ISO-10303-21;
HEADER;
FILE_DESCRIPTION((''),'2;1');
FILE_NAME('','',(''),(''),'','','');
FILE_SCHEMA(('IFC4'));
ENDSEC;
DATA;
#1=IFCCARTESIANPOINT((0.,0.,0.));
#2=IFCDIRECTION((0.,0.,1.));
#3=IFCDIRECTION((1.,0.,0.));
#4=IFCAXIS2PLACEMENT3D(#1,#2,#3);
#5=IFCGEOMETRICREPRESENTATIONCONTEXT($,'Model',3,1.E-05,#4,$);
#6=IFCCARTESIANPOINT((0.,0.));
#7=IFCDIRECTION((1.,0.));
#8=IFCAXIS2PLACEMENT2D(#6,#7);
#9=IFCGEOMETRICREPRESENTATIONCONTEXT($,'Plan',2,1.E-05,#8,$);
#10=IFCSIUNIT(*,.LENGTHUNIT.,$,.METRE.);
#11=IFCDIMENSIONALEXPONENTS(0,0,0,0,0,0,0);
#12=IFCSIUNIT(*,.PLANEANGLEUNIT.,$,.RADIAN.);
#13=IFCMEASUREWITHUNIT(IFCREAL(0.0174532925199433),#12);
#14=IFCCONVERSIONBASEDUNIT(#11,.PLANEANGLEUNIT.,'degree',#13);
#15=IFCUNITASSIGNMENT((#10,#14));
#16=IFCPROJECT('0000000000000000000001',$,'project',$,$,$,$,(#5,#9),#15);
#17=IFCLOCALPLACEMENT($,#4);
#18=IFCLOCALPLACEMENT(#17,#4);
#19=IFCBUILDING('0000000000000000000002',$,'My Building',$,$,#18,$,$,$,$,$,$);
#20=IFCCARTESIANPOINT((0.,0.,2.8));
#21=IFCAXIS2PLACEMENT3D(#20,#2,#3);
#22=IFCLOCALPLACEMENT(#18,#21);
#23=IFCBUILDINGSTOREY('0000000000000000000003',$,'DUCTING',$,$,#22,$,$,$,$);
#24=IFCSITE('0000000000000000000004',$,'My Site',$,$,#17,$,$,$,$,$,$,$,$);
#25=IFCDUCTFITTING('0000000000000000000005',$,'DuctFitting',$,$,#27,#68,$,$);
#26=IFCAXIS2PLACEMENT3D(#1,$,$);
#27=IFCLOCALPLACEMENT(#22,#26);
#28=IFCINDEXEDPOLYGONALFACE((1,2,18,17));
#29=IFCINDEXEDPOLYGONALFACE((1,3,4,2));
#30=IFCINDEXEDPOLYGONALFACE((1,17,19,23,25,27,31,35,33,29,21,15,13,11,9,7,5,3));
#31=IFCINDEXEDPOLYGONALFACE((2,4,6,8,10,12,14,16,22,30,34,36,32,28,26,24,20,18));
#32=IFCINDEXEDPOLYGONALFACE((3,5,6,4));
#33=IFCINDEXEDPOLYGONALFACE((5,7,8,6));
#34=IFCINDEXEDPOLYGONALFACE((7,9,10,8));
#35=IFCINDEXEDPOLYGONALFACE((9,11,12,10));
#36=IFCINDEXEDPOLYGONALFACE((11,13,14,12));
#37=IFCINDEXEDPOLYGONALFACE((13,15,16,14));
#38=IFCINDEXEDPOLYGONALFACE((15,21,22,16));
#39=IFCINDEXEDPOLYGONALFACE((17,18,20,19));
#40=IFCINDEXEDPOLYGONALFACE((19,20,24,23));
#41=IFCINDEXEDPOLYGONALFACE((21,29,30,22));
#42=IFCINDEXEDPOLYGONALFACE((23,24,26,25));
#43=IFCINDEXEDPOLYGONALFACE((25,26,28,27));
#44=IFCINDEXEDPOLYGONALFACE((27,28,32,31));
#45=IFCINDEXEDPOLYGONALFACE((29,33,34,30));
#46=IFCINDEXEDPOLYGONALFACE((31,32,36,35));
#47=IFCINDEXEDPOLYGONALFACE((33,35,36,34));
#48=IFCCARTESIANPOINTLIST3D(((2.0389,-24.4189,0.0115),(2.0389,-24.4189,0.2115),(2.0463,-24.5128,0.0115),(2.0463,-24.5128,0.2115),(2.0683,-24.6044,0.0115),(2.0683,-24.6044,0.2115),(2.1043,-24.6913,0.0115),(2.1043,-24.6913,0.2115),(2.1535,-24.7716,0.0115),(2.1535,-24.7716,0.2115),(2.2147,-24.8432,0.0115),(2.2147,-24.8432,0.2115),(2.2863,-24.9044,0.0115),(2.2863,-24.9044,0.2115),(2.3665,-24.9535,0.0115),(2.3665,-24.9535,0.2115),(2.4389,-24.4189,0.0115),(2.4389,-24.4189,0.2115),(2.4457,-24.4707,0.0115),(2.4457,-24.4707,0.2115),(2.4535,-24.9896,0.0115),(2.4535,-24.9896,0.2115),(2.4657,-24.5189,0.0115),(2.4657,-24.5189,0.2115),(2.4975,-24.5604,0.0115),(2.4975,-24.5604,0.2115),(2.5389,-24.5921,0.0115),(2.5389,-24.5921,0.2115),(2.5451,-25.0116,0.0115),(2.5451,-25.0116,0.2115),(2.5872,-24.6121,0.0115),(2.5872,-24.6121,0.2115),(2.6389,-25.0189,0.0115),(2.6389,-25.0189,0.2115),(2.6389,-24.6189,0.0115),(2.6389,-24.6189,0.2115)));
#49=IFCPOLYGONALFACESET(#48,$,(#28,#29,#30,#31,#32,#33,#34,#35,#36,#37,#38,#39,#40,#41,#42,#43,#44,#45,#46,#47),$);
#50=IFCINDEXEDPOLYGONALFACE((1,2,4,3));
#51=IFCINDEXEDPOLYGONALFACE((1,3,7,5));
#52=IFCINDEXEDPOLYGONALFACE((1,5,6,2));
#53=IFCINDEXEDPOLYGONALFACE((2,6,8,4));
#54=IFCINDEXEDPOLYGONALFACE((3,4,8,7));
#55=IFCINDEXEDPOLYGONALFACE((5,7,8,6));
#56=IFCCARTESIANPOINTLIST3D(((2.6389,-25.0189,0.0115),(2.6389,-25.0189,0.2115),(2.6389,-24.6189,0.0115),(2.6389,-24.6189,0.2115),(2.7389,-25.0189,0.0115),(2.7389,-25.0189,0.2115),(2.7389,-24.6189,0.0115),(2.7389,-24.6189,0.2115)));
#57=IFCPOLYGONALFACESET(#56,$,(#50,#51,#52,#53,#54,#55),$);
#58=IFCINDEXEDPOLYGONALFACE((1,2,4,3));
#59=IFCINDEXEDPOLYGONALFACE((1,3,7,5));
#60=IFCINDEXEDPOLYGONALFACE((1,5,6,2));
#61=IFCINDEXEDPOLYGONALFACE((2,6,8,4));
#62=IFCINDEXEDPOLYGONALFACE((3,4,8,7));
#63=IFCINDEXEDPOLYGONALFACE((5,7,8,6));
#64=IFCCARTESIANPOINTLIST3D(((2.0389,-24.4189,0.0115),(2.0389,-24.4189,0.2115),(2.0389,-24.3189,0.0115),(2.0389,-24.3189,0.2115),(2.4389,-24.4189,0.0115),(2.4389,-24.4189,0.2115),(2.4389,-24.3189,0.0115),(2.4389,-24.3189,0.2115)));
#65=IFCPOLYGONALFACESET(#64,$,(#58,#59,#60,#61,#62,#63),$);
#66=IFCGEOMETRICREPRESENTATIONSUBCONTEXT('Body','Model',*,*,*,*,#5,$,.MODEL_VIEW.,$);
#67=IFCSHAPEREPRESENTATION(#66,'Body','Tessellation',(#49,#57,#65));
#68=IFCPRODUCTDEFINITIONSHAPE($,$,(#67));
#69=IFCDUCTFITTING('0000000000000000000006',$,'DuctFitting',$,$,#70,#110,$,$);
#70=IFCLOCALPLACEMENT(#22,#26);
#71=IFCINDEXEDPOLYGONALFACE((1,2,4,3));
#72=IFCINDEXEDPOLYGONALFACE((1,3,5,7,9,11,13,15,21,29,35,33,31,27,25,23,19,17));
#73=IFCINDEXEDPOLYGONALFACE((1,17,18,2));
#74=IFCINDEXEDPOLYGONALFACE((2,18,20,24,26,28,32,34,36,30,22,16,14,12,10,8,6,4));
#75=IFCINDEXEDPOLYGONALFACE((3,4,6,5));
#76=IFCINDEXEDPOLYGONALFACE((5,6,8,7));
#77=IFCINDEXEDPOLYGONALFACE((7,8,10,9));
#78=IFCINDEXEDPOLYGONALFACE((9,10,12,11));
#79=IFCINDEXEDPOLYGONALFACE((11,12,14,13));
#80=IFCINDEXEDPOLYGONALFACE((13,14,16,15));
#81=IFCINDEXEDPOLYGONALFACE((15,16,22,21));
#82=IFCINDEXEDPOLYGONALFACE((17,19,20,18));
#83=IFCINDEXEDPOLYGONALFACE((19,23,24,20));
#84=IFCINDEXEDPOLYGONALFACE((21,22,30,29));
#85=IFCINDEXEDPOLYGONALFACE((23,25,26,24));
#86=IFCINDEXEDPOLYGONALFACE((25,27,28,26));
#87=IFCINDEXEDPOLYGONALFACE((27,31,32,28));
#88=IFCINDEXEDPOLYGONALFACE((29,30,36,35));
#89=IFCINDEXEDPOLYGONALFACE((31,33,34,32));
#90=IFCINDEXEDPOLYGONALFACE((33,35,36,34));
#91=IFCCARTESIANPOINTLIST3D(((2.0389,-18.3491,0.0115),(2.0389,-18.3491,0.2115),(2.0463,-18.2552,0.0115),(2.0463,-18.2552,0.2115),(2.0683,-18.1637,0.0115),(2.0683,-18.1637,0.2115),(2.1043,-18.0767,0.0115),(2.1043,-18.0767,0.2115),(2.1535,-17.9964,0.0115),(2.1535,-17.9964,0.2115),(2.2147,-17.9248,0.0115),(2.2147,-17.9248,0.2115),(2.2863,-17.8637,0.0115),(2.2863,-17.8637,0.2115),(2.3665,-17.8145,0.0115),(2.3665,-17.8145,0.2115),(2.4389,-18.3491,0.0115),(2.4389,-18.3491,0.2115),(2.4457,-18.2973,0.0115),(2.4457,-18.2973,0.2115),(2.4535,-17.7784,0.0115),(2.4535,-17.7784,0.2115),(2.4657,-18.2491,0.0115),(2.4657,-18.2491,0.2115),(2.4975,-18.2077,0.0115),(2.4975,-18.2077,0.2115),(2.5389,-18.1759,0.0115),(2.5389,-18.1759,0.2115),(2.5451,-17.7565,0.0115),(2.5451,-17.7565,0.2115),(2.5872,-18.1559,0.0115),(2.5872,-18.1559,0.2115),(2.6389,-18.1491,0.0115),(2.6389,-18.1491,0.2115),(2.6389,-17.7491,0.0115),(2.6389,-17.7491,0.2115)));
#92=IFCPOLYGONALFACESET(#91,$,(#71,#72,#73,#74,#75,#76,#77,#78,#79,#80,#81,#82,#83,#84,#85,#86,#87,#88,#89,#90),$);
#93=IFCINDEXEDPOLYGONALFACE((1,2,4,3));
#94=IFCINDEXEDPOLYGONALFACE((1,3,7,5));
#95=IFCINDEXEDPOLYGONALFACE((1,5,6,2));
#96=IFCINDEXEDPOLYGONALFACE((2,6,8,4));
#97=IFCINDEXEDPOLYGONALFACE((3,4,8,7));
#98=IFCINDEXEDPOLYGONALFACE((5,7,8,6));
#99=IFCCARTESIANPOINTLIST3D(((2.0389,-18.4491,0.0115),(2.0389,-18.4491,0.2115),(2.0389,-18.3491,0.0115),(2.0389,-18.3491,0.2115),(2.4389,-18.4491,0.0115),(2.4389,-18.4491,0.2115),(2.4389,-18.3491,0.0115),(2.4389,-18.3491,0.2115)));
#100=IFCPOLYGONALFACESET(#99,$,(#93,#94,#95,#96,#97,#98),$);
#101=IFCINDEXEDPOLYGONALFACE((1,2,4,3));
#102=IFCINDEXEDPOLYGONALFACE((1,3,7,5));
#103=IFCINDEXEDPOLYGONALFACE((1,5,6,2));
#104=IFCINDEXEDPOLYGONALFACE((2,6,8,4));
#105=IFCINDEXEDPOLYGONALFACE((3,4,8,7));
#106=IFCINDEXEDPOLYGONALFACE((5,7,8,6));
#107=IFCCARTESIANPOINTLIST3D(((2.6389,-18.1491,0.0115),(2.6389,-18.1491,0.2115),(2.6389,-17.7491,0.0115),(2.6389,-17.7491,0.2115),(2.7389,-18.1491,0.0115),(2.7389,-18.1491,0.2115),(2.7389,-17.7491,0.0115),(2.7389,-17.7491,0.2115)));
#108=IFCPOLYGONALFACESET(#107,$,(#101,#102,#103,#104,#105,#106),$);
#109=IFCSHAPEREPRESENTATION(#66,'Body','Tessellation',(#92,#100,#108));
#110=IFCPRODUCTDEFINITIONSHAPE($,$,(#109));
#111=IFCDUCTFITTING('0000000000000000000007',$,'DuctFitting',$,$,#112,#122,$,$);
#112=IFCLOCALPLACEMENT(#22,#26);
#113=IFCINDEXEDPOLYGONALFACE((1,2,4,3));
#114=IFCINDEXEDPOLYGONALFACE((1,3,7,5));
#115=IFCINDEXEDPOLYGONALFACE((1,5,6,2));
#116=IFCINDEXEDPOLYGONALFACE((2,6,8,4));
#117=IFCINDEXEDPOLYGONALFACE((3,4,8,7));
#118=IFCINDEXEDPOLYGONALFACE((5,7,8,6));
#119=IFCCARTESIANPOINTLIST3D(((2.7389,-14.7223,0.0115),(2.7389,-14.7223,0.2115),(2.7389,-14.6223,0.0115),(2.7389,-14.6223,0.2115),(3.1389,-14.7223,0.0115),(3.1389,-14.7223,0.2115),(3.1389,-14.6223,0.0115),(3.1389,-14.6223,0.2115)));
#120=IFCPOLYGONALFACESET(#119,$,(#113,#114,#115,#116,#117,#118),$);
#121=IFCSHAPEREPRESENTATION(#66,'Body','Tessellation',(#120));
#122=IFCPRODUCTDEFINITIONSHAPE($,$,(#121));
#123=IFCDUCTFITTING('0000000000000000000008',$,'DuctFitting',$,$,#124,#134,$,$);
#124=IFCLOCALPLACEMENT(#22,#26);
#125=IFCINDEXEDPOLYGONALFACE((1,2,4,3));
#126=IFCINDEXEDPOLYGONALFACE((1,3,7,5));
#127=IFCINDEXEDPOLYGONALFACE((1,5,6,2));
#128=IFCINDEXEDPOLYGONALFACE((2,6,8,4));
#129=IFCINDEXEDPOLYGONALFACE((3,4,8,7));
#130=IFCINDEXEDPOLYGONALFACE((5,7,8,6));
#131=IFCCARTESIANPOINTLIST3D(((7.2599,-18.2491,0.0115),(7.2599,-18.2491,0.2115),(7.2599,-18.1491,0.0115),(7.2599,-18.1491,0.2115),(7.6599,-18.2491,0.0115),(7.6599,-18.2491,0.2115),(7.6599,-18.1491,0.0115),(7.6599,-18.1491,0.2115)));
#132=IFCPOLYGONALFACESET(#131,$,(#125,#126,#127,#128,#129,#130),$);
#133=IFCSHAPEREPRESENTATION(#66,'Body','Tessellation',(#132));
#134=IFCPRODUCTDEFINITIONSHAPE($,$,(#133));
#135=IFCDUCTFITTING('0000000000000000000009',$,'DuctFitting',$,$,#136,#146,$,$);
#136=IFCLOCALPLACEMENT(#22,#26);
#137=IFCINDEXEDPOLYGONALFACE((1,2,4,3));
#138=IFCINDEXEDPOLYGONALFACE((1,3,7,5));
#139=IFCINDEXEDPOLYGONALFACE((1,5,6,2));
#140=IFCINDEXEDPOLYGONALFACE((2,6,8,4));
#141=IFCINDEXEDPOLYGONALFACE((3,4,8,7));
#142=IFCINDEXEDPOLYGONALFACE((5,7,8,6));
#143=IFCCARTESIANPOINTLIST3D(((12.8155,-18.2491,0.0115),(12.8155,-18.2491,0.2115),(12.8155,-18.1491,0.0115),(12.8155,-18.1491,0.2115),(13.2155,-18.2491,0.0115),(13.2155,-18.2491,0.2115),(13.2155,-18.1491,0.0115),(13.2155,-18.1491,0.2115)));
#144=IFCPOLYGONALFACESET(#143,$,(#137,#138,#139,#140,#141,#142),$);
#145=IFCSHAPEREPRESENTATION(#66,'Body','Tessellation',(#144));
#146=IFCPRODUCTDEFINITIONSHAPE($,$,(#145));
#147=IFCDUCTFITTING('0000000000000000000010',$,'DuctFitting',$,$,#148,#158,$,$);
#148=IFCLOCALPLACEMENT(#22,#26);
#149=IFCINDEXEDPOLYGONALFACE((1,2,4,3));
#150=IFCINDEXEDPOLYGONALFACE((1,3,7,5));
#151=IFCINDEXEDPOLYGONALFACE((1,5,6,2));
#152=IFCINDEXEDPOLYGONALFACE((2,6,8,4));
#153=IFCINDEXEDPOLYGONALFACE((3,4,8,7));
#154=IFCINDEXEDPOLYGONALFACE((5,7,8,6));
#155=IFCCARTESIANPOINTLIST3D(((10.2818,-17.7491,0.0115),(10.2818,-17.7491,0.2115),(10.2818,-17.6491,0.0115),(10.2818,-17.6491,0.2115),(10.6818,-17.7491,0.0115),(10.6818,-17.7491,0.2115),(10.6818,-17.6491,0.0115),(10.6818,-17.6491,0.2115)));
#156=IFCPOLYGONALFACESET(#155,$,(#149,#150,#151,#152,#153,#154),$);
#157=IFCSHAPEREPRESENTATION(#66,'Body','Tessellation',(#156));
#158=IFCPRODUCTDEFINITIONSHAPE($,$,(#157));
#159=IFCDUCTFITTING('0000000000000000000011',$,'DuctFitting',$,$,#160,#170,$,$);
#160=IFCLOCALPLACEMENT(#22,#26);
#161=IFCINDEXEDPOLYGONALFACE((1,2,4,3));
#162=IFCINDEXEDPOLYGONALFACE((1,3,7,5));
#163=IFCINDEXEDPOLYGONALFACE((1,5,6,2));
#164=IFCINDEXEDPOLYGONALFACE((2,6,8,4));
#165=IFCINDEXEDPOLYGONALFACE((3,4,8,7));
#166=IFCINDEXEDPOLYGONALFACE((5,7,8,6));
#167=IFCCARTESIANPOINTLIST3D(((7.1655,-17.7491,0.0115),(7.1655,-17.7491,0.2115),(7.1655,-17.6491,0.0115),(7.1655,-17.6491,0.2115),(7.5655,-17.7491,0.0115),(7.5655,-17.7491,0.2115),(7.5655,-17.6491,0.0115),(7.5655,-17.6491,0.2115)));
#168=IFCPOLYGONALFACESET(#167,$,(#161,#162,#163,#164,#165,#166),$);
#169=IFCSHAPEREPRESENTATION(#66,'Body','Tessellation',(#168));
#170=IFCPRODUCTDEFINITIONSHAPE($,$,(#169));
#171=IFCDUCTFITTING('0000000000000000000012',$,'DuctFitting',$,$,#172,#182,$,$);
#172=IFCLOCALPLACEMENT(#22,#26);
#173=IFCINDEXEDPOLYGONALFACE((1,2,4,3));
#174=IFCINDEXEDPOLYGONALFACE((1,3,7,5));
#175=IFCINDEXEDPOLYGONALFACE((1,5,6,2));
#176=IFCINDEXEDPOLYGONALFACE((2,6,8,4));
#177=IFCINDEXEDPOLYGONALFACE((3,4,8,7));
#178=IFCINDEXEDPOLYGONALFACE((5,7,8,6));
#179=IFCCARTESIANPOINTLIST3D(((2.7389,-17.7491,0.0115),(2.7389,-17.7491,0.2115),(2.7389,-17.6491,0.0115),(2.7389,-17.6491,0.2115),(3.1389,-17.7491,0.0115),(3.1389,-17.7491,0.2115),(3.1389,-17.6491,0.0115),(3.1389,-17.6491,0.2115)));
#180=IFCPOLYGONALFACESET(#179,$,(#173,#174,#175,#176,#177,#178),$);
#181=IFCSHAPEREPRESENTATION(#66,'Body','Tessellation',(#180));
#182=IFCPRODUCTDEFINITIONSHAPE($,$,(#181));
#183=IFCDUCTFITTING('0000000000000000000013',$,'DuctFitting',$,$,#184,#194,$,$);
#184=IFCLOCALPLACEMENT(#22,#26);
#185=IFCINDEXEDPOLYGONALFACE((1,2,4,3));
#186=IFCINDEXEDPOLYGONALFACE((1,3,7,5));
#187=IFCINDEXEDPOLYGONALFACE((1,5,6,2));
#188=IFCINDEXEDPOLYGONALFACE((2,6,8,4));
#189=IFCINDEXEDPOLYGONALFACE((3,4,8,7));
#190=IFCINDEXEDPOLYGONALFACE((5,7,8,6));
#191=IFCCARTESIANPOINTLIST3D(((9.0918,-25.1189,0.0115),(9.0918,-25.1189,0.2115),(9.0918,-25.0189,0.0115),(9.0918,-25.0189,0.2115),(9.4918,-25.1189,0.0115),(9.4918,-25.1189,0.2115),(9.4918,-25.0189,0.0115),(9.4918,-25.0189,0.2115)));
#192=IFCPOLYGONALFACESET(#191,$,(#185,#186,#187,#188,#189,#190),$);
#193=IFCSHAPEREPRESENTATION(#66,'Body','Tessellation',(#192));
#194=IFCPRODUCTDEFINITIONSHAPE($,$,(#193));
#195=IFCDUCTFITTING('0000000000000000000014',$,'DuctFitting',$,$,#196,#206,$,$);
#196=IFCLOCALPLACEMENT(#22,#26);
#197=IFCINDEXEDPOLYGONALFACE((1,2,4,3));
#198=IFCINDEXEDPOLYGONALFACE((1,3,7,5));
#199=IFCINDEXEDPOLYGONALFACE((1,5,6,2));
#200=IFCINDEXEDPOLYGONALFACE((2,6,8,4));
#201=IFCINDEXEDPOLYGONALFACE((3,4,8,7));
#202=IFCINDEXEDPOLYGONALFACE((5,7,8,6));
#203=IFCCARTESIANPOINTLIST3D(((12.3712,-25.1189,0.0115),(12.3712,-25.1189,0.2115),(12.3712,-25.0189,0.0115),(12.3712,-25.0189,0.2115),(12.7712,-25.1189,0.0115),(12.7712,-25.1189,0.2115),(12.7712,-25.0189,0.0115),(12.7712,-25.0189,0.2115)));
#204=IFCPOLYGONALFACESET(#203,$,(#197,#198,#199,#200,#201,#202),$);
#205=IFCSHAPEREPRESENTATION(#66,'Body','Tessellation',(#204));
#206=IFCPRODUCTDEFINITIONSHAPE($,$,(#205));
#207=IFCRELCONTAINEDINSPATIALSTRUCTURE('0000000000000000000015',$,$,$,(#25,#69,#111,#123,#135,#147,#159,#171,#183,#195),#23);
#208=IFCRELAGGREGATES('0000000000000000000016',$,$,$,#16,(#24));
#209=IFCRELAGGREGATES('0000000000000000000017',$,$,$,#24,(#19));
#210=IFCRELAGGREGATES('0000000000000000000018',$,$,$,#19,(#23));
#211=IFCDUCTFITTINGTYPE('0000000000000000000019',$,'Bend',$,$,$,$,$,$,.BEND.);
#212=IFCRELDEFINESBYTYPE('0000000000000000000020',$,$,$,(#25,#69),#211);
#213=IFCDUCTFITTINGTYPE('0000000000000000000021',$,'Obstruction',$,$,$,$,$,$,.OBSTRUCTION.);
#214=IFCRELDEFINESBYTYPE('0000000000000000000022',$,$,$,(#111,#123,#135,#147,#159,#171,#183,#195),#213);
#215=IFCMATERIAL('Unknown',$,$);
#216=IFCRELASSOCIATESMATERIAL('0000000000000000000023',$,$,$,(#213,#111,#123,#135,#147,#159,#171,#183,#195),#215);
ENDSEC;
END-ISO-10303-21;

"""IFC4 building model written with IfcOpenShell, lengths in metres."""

from ifc_helpers import new_model, entity, si_unit, converted_unit, frame, origin_with_axes, origin_2d_with_axis, place, context, subcontext, project, spatial, line, arc, indexed_curve, rectangle, outline, extrude, source, transform, mapped, material, material_profile, profile_set, profile_usage, type_object, type_shapes, element, save


model = new_model("IFC4")

# Units and contexts
model_context = context("Model", 3, precision=1e-05, world=origin_with_axes())
plan_context = context("Plan", 2, precision=1e-05, world=origin_2d_with_axis())
body_context = subcontext(model_context, "Body", "Model", "MODEL_VIEW")
ifc_project = project(units=[si_unit("LENGTHUNIT", "METRE"), converted_unit("PLANEANGLEUNIT", "degree", entity("IfcReal", 0.0174532925199433), si_unit("PLANEANGLEUNIT", "RADIAN"), dimensions=[0, 0, 0, 0, 0, 0, 0])], contexts=[model_context, plan_context])

# Site, building, storey
site_placement = place(None, origin_with_axes())
site = spatial("IfcSite", under=ifc_project, at=site_placement, Name="My Site")
building_placement = place(site_placement, origin_with_axes())
building = spatial("IfcBuilding", under=site, at=building_placement, Name="My Building")
storey_placement = place(building_placement, frame((0.0, 0.0, 2.8), z_axis=(0.0, 0.0, 1.0), x_axis=(1.0, 0.0, 0.0)))
storey = spatial("IfcBuildingStorey", under=building, at=storey_placement, Name="DUCTING")

# Shared definitions
ifc_material = material(Name="Unknown")

# Duct fittings
duct_fitting_type_1 = type_object("IfcDuctFittingType", Name="Bend", PredefinedType="BEND")
shared_shape = source(origin_with_axes(), body_context, "Body", "SweptSolid", [
    extrude(outline(indexed_curve([(0.2, 0.0), (0.2586, -0.1414), (0.4, -0.2), (0.4, -0.6), (-0.0243, -0.4243), (-0.2, 0.0)], segments=[arc(1, 2, 3), line(3, 4), arc(4, 5, 6), line(6, 1)])), frame((0.0, -0.1, -0.1), z_axis=(0.0, -1.0, 0.0), x_axis=(1.0, 0.0, 0.0)), (0.0, 0.0, -1.0), 0.2),
    extrude(rectangle(XDim=0.4, YDim=0.2), origin_with_axes(), (0.0, 0.0, -1.0), 0.1),
    extrude(rectangle(XDim=0.4, YDim=0.2), frame((0.4, 0.0, -0.5), z_axis=(1.0, 0.0, 0.0), x_axis=(0.0, 0.0, 1.0)), (0.0, 0.0, 1.0), 0.1),
])
type_shapes(duct_fitting_type_1, [shared_shape])
for number, where, z_axis, x_axis, name in (
    (1, (2.7389, -24.8189, 0.1115), (1.0, 0.0, 0.0), (0.0, 1.0, 0.0), "DuctFitting"),
    (2, (2.2389, -18.4491, 0.1115), (0.0, -1.0, 0.0), (1.0, 0.0, 0.0), "DuctFitting"),
):
    element("IfcDuctFitting", number, at=place(storey_placement, frame(where, z_axis=z_axis, x_axis=x_axis)), inside=storey, type_object=duct_fitting_type_1, Name=name, context=body_context, shape_type="MappedRepresentation", body=[
        mapped(shared_shape, transform((0.0, 0.0, 0.0), x_axis=(1.0, 0.0, 0.0), y_axis=(0.0, 1.0, 0.0), z_axis=(0.0, 0.0, 1.0), scale=1.0)),
    ])
ifc_material_profile_1 = material_profile(ifc_material, rectangle(XDim=0.4, YDim=0.2))
ifc_profile_set_1 = profile_set([ifc_material_profile_1])
ifc_profile_usage_1 = profile_usage(ifc_profile_set_1, cardinal=5)
duct_fitting_type_2 = type_object("IfcDuctFittingType", Name="Obstruction", PredefinedType="OBSTRUCTION", material=ifc_profile_set_1)
duct_fitting_1_placement = place(storey_placement, frame((2.9389, -14.7223, 0.1115), z_axis=(0.0, 1.0, 0.0), x_axis=(-1.0, 0.0, 0.0)))
element("IfcDuctFitting", 3, at=duct_fitting_1_placement, inside=storey, type_object=duct_fitting_type_2, material=ifc_profile_usage_1, Name="DuctFitting", context=body_context, shape_type="SweptSolid", body=[
    extrude(rectangle(XDim=0.4, YDim=0.2), origin_with_axes(), (0.0, 0.0, 1.0), 0.1),
])
ifc_profile_usage_2 = profile_usage(ifc_profile_set_1, cardinal=5)
duct_fitting_2_placement = place(storey_placement, frame((7.4599, -18.1491, 0.1115), z_axis=(0.000001, -1.0, 0.0), x_axis=(1.0, 0.000001, 0.0)))
element("IfcDuctFitting", 4, at=duct_fitting_2_placement, inside=storey, type_object=duct_fitting_type_2, material=ifc_profile_usage_2, Name="DuctFitting", context=body_context, shape_type="SweptSolid", body=[
    extrude(rectangle(XDim=0.4, YDim=0.2), origin_with_axes(), (0.0, 0.0, 1.0), 0.1),
])
ifc_profile_usage_3 = profile_usage(ifc_profile_set_1, cardinal=5)
duct_fitting_3_placement = place(storey_placement, frame((13.0155, -18.1491, 0.1115), z_axis=(0.000001, -1.0, 0.0), x_axis=(1.0, 0.000001, 0.0)))
element("IfcDuctFitting", 5, at=duct_fitting_3_placement, inside=storey, type_object=duct_fitting_type_2, material=ifc_profile_usage_3, Name="DuctFitting", context=body_context, shape_type="SweptSolid", body=[
    extrude(rectangle(XDim=0.4, YDim=0.2), origin_with_axes(), (0.0, 0.0, 1.0), 0.1),
])
ifc_profile_usage_4 = profile_usage(ifc_profile_set_1, cardinal=5)
duct_fitting_4_placement = place(storey_placement, frame((10.4818, -17.6491, 0.1115), z_axis=(0.0, -1.0, 0.0), x_axis=(1.0, 0.0, 0.0)))
element("IfcDuctFitting", 6, at=duct_fitting_4_placement, inside=storey, type_object=duct_fitting_type_2, material=ifc_profile_usage_4, Name="DuctFitting", context=body_context, shape_type="SweptSolid", body=[
    extrude(rectangle(XDim=0.4, YDim=0.2), origin_with_axes(), (0.0, 0.0, 1.0), 0.1),
])
ifc_profile_usage_5 = profile_usage(ifc_profile_set_1, cardinal=5)
duct_fitting_5_placement = place(storey_placement, frame((7.3655, -17.6491, 0.1115), z_axis=(0.0, -1.0, 0.0), x_axis=(1.0, 0.0, 0.0)))
element("IfcDuctFitting", 7, at=duct_fitting_5_placement, inside=storey, type_object=duct_fitting_type_2, material=ifc_profile_usage_5, Name="DuctFitting", context=body_context, shape_type="SweptSolid", body=[
    extrude(rectangle(XDim=0.4, YDim=0.2), origin_with_axes(), (0.0, 0.0, 1.0), 0.1),
])
ifc_profile_usage_6 = profile_usage(ifc_profile_set_1, cardinal=5)
duct_fitting_6_placement = place(storey_placement, frame((2.9389, -17.6491, 0.1115), z_axis=(0.0, -1.0, 0.0), x_axis=(1.0, 0.0, 0.0)))
element("IfcDuctFitting", 8, at=duct_fitting_6_placement, inside=storey, type_object=duct_fitting_type_2, material=ifc_profile_usage_6, Name="DuctFitting", context=body_context, shape_type="SweptSolid", body=[
    extrude(rectangle(XDim=0.4, YDim=0.2), origin_with_axes(), (0.0, 0.0, 1.0), 0.1),
])
ifc_profile_usage_7 = profile_usage(ifc_profile_set_1, cardinal=5)
duct_fitting_7_placement = place(storey_placement, frame((9.2918, -25.0189, 0.1115), z_axis=(0.000001, -1.0, 0.0), x_axis=(1.0, 0.000001, 0.0)))
element("IfcDuctFitting", 9, at=duct_fitting_7_placement, inside=storey, type_object=duct_fitting_type_2, material=ifc_profile_usage_7, Name="DuctFitting", context=body_context, shape_type="SweptSolid", body=[
    extrude(rectangle(XDim=0.4, YDim=0.2), origin_with_axes(), (0.0, 0.0, 1.0), 0.1),
])
ifc_profile_usage_8 = profile_usage(ifc_profile_set_1, cardinal=5)
duct_fitting_8_placement = place(storey_placement, frame((12.5712, -25.0189, 0.1115), z_axis=(0.000001, -1.0, 0.0), x_axis=(1.0, 0.000001, 0.0)))
element("IfcDuctFitting", 10, at=duct_fitting_8_placement, inside=storey, type_object=duct_fitting_type_2, material=ifc_profile_usage_8, Name="DuctFitting", context=body_context, shape_type="SweptSolid", body=[
    extrude(rectangle(XDim=0.4, YDim=0.2), origin_with_axes(), (0.0, 0.0, 1.0), 0.1),
])

save(model, "model.ifc")
